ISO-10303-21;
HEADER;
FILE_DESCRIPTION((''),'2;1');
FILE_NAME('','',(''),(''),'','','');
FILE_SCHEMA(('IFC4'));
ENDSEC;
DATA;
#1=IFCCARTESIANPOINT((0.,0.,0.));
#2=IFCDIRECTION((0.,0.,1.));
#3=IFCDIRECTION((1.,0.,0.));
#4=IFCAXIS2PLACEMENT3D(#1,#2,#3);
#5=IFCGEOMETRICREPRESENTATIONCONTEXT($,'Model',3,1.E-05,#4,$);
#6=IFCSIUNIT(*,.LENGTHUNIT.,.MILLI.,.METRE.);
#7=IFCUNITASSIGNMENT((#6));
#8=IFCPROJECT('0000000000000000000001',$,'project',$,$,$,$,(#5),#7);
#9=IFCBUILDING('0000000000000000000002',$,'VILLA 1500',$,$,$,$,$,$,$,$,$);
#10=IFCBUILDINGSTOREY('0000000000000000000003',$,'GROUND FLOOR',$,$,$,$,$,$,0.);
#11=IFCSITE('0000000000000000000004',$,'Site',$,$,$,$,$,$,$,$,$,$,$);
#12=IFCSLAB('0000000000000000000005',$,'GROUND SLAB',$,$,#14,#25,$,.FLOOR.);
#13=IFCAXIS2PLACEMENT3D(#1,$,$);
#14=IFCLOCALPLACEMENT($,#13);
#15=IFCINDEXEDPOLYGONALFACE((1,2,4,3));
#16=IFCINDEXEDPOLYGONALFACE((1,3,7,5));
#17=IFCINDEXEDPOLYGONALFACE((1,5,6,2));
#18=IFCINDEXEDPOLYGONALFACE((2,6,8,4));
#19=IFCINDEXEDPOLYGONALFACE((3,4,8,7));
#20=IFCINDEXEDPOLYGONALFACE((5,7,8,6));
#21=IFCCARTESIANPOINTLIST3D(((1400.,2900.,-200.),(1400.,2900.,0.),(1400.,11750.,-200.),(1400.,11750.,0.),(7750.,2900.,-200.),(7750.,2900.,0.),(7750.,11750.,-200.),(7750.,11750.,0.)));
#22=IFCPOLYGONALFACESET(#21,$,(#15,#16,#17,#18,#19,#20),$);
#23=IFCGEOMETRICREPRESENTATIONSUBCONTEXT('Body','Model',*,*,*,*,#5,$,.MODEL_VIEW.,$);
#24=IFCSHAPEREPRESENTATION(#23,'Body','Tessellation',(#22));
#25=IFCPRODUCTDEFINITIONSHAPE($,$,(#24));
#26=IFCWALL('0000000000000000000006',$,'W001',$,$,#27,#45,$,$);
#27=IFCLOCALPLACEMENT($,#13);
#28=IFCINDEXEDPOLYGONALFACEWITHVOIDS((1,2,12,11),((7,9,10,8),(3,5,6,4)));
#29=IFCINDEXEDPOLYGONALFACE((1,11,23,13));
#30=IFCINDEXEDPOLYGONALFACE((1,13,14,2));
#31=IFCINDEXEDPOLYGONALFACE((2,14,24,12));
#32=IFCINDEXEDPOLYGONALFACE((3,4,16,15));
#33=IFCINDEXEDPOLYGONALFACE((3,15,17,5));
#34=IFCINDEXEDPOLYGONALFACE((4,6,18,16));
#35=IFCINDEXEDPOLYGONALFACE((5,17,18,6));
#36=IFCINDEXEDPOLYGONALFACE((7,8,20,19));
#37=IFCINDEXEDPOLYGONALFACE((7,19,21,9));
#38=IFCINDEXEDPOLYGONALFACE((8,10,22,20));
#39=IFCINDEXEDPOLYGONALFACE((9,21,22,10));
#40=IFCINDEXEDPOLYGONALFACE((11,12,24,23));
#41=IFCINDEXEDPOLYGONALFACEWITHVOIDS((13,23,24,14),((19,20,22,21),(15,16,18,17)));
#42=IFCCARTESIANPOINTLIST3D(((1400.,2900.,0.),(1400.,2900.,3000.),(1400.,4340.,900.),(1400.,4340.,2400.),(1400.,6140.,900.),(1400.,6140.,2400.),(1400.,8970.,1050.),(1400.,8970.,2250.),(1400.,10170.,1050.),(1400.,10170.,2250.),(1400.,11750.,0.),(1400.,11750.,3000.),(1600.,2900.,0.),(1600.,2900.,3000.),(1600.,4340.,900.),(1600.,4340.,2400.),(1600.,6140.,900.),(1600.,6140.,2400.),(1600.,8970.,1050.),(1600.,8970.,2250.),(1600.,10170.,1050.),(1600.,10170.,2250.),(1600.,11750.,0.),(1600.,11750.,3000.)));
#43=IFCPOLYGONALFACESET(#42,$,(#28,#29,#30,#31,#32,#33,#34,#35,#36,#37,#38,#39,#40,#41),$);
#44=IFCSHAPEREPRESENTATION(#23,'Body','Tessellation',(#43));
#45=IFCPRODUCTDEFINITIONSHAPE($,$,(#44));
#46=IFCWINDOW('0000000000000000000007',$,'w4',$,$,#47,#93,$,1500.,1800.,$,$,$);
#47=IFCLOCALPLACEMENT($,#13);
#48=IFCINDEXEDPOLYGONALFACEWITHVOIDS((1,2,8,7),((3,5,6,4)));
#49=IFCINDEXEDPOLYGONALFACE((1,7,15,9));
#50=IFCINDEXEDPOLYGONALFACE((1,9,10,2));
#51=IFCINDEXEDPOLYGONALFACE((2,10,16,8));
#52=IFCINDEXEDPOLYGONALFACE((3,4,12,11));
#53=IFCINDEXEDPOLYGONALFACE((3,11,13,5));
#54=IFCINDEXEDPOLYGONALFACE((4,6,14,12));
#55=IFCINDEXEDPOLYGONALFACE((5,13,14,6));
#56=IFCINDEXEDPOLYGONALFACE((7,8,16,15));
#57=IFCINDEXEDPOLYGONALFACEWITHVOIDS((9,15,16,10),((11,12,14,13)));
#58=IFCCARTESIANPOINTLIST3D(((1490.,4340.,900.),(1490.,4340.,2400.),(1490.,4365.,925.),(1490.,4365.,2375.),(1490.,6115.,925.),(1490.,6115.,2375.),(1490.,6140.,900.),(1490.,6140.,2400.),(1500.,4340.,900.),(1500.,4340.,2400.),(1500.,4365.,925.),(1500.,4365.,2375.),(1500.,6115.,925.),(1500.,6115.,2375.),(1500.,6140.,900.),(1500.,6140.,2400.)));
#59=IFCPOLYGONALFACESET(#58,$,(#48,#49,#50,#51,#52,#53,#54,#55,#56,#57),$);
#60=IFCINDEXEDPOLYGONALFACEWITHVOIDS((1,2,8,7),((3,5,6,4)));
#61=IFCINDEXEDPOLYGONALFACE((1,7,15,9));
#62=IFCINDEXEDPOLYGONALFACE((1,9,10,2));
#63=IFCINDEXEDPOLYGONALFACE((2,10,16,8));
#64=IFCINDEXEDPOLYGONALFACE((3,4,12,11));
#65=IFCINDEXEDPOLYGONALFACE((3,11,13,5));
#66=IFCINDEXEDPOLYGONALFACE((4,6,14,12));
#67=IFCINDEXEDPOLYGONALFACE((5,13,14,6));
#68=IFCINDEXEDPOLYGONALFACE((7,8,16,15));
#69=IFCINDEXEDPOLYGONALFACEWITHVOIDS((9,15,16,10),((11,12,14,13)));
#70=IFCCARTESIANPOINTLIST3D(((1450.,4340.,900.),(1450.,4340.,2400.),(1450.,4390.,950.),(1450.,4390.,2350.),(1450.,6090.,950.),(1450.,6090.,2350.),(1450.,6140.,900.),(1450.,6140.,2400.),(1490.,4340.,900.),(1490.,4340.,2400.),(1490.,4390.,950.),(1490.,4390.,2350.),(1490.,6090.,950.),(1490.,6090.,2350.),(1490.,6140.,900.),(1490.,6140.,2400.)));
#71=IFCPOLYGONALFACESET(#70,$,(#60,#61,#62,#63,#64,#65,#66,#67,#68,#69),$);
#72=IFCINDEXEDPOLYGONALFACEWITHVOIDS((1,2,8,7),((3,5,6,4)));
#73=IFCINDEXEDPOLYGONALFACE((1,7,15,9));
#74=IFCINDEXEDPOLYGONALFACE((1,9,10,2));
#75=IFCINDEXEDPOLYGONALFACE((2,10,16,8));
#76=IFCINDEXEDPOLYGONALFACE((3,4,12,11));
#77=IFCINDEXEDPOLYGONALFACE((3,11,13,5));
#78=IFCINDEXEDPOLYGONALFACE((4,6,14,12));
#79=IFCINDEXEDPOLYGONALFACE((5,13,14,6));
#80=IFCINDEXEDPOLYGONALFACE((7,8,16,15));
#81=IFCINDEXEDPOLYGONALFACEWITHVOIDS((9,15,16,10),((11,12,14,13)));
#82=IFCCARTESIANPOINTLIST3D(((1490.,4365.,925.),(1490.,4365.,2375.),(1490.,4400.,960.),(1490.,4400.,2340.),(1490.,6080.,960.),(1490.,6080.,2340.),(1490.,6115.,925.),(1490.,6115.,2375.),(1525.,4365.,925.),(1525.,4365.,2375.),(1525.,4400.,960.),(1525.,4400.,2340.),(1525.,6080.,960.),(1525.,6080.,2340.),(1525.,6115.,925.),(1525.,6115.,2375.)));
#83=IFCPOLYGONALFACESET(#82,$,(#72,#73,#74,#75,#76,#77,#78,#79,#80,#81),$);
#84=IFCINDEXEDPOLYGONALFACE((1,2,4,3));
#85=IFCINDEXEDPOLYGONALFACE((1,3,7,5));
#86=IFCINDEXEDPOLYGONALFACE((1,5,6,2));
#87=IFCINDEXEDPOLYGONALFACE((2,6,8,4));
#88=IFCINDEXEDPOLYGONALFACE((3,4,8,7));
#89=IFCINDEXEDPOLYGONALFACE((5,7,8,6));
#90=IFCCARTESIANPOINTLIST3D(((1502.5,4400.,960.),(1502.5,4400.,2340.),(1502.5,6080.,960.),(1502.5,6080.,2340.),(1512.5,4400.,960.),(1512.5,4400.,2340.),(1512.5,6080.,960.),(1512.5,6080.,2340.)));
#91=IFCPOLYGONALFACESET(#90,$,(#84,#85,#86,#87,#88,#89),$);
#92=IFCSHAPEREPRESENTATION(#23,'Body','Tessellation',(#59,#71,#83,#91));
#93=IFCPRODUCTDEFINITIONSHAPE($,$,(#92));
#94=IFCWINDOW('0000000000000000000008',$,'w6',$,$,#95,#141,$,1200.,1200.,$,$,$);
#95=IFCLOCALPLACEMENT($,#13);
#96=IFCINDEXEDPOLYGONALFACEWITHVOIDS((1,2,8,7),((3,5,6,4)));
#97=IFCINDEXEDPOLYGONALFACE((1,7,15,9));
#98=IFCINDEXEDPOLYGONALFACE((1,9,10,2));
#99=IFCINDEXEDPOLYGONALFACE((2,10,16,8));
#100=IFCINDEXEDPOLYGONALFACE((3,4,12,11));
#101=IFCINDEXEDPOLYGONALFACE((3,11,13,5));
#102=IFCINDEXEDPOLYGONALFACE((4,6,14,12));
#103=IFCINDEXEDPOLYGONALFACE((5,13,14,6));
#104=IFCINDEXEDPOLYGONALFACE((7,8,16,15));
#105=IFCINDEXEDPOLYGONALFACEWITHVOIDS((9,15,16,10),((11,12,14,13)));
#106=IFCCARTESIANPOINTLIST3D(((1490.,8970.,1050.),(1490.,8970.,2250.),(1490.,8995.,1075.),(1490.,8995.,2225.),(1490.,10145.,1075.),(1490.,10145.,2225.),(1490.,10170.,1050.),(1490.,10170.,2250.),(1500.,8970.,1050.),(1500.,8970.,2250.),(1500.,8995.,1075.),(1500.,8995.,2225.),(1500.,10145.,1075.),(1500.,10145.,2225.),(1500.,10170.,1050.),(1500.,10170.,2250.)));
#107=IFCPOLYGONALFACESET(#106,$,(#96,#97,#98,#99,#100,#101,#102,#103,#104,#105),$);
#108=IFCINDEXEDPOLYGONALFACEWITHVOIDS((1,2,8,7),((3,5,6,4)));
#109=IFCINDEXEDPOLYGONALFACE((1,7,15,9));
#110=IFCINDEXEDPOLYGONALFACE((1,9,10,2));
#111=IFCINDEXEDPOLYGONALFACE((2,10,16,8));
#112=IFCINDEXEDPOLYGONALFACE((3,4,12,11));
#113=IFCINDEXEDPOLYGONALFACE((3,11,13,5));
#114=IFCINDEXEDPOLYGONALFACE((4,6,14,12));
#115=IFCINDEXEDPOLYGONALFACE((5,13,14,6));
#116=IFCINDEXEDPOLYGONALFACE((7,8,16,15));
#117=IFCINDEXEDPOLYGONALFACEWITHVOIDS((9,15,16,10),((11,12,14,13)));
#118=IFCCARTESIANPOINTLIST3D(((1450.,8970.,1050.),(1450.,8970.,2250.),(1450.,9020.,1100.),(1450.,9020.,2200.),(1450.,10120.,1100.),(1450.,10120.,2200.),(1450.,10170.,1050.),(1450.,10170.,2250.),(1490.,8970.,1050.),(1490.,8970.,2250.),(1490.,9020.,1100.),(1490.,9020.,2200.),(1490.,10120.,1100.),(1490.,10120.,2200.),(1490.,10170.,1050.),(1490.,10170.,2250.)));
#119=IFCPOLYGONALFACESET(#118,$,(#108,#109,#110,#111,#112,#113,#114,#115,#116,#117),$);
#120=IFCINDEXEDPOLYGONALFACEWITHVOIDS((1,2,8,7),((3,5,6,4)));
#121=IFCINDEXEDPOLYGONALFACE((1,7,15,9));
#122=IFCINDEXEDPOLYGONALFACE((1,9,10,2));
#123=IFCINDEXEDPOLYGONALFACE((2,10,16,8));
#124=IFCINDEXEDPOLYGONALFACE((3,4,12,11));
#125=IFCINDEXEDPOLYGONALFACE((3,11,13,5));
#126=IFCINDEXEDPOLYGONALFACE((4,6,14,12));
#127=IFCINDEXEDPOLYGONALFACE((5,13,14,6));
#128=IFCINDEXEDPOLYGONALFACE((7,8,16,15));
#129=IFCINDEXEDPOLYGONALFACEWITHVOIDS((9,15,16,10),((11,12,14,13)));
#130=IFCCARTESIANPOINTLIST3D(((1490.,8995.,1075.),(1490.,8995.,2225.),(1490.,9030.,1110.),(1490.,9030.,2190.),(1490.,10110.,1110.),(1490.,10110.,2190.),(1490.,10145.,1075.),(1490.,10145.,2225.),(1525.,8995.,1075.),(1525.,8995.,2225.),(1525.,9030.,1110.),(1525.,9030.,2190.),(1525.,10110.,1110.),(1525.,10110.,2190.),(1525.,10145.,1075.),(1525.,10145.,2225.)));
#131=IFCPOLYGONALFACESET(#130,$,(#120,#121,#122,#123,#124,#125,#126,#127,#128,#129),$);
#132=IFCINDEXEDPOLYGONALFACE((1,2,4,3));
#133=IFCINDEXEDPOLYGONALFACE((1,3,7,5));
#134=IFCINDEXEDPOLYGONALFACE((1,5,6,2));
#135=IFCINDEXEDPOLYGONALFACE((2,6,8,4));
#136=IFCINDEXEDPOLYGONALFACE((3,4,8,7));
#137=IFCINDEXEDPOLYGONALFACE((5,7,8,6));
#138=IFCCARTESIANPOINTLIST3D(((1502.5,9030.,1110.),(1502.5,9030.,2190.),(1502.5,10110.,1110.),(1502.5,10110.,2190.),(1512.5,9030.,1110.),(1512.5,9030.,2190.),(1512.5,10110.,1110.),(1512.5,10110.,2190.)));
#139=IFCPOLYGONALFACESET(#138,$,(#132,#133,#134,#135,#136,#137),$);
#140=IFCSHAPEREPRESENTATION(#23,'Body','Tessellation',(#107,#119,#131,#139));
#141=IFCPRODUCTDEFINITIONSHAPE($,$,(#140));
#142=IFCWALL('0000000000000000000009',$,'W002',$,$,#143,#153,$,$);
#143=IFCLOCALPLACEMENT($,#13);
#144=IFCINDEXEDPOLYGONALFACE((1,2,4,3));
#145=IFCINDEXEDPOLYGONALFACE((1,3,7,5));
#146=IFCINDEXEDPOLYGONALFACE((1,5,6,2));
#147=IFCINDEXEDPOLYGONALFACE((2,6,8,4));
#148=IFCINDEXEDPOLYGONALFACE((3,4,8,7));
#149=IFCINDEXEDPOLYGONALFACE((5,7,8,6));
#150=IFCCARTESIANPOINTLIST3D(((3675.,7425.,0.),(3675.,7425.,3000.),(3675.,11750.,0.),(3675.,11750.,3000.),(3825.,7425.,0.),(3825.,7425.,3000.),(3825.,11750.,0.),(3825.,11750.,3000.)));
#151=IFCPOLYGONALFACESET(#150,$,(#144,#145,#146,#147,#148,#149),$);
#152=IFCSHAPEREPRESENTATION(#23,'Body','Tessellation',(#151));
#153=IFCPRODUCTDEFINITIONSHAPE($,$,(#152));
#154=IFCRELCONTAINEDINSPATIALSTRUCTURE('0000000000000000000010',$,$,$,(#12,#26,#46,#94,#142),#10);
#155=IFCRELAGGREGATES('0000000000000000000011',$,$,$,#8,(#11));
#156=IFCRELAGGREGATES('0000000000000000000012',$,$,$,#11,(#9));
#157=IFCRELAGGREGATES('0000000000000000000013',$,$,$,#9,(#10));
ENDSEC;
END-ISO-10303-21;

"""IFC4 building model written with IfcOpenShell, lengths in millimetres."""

from ifc_helpers import new_model, si_unit, frame, origin_with_axes, place, context, subcontext, project, spatial, line, indexed_curve, outline, extrude, element, fill, save


model = new_model("IFC4")

# Units and contexts
model_context = context("Model", 3, precision=1e-05, world=origin_with_axes())
body_context = subcontext(model_context, "Body", "Model", "MODEL_VIEW")
ifc_project = project(units=[si_unit("LENGTHUNIT", "METRE", prefix="MILLI")], contexts=[model_context])

# Site, building, storey
site = spatial("IfcSite", under=ifc_project, Name="Site")
building = spatial("IfcBuilding", under=site, Name="VILLA 1500")
storey = spatial("IfcBuildingStorey", under=building, Name="GROUND FLOOR", Elevation=0.0)

# Slab
slab_placement = place(None, frame((0.0, 0.0, -200.0), z_axis=(0.0, 0.0, 1.0), x_axis=(1.0, 0.0, 0.0)))
element("IfcSlab", 1, at=slab_placement, inside=storey, Name="GROUND SLAB", PredefinedType="FLOOR", context=body_context, shape_type="SweptSolid", body=[
    extrude(outline(indexed_curve([(1400.0, 2900.0), (7750.0, 2900.0), (7750.0, 11750.0), (1400.0, 11750.0)])), None, (0.0, 0.0, 1.0), 200.0),
])

# Wall, openings, windows
wall_1_placement = place(None, frame((1500.0, 11750.0, 0.0), z_axis=(0.0, 0.0, 1.0), x_axis=(0.0, -1.0, 0.0)))
wall_1 = element("IfcWall", 2, at=wall_1_placement, inside=storey, Name="W001", context=body_context, shape_type="SweptSolid", body=[
    extrude(outline(indexed_curve([(0.0, 0.0), (0.0, 200.0), (8850.0, 200.0), (8850.0, 0.0), (0.0, 0.0)], self_intersect=False)), frame((0.0, -100.0, 0.0), z_axis=(0.0, 0.0, 1.0), x_axis=(1.0, 0.0, 0.0)), (0.0, 0.0, 1.0), 3000.0),
])
opening_1_placement = place(wall_1_placement, frame((5610.0, 0.0, 900.0), z_axis=(0.0, 0.0, 1.0), x_axis=(1.0, 0.0, 0.0)))
opening_1 = element("IfcOpeningElement", 3, at=opening_1_placement, cuts=wall_1, context=body_context, shape_type="SweptSolid", body=[
    extrude(outline(indexed_curve([(0.0, 0.0), (0.0, 300.0), (1800.0, 300.0), (1800.0, 0.0), (0.0, 0.0)], self_intersect=False)), frame((0.0, -150.0, 0.0), z_axis=(0.0, 0.0, 1.0), x_axis=(1.0, 0.0, 0.0)), (0.0, 0.0, 1.0), 1500.0),
])
opening_2_placement = place(wall_1_placement, frame((1580.0, 0.0, 1050.0), z_axis=(0.0, 0.0, 1.0), x_axis=(1.0, 0.0, 0.0)))
opening_2 = element("IfcOpeningElement", 4, at=opening_2_placement, cuts=wall_1, context=body_context, shape_type="SweptSolid", body=[
    extrude(outline(indexed_curve([(0.0, 0.0), (0.0, 300.0), (1200.0, 300.0), (1200.0, 0.0), (0.0, 0.0)], self_intersect=False)), frame((0.0, -150.0, 0.0), z_axis=(0.0, 0.0, 1.0), x_axis=(1.0, 0.0, 0.0)), (0.0, 0.0, 1.0), 1200.0),
])
window_1_placement = place(None, frame((1400.0, 6140.0, 900.0), z_axis=(0.0, 0.0, 1.0), x_axis=(0.0, -1.0, 0.0)))
window_1 = element("IfcWindow", 5, at=window_1_placement, inside=storey, Name="w4", OverallHeight=1500.0, OverallWidth=1800.0, context=body_context, shape_type="SweptSolid", body=[
    extrude(outline(indexed_curve([(0.0, 0.0), (1800.0, 0.0), (1800.0, 1500.0), (0.0, 1500.0)], segments=[line(1, 2, 3, 4, 1)]), holes=[indexed_curve([(25.0, 25.0), (1775.0, 25.0), (1775.0, 1475.0), (25.0, 1475.0)], segments=[line(1, 2, 3, 4, 1)])]), frame((0.0, 90.0, 0.0), z_axis=(0.0, -1.0, 0.0), x_axis=(1.0, 0.0, 0.0)), (0.0, 0.0, -1.0), 10.0),
    extrude(outline(indexed_curve([(0.0, 0.0), (1800.0, 0.0), (1800.0, 1500.0), (0.0, 1500.0)], segments=[line(1, 2, 3, 4, 1)]), holes=[indexed_curve([(50.0, 50.0), (1750.0, 50.0), (1750.0, 1450.0), (50.0, 1450.0)], segments=[line(1, 2, 3, 4, 1)])]), frame((0.0, 50.0, 0.0), z_axis=(0.0, -1.0, 0.0), x_axis=(1.0, 0.0, 0.0)), (0.0, 0.0, -1.0), 40.0),
    extrude(outline(indexed_curve([(0.0, 0.0), (1750.0, 0.0), (1750.0, 1450.0), (0.0, 1450.0)], segments=[line(1, 2, 3, 4, 1)]), holes=[indexed_curve([(35.0, 35.0), (1715.0, 35.0), (1715.0, 1415.0), (35.0, 1415.0)], segments=[line(1, 2, 3, 4, 1)])]), frame((25.0, 90.0, 25.0), z_axis=(0.0, -1.0, 0.0), x_axis=(1.0, 0.0, 0.0)), (0.0, 0.0, -1.0), 35.0),
    extrude(outline(indexed_curve([(35.0, 35.0), (1715.0, 35.0), (1715.0, 1415.0), (35.0, 1415.0)], segments=[line(1, 2, 3, 4, 1)])), frame((25.0, 102.5, 25.0), z_axis=(0.0, -1.0, 0.0), x_axis=(1.0, 0.0, 0.0)), (0.0, 0.0, -1.0), 10.0),
])
fill(opening_1, window_1)
window_2_placement = place(None, frame((1400.0, 10170.0, 1050.0), z_axis=(0.0, 0.0, 1.0), x_axis=(0.0, -1.0, 0.0)))
window_2 = element("IfcWindow", 6, at=window_2_placement, inside=storey, Name="w6", OverallHeight=1200.0, OverallWidth=1200.0, context=body_context, shape_type="SweptSolid", body=[
    extrude(outline(indexed_curve([(0.0, 0.0), (1200.0, 0.0), (1200.0, 1200.0), (0.0, 1200.0)], segments=[line(1, 2, 3, 4, 1)]), holes=[indexed_curve([(25.0, 25.0), (1175.0, 25.0), (1175.0, 1175.0), (25.0, 1175.0)], segments=[line(1, 2, 3, 4, 1)])]), frame((0.0, 90.0, 0.0), z_axis=(0.0, -1.0, 0.0), x_axis=(1.0, 0.0, 0.0)), (0.0, 0.0, -1.0), 10.0),
    extrude(outline(indexed_curve([(0.0, 0.0), (1200.0, 0.0), (1200.0, 1200.0), (0.0, 1200.0)], segments=[line(1, 2, 3, 4, 1)]), holes=[indexed_curve([(50.0, 50.0), (1150.0, 50.0), (1150.0, 1150.0), (50.0, 1150.0)], segments=[line(1, 2, 3, 4, 1)])]), frame((0.0, 50.0, 0.0), z_axis=(0.0, -1.0, 0.0), x_axis=(1.0, 0.0, 0.0)), (0.0, 0.0, -1.0), 40.0),
    extrude(outline(indexed_curve([(0.0, 0.0), (1150.0, 0.0), (1150.0, 1150.0), (0.0, 1150.0)], segments=[line(1, 2, 3, 4, 1)]), holes=[indexed_curve([(35.0, 35.0), (1115.0, 35.0), (1115.0, 1115.0), (35.0, 1115.0)], segments=[line(1, 2, 3, 4, 1)])]), frame((25.0, 90.0, 25.0), z_axis=(0.0, -1.0, 0.0), x_axis=(1.0, 0.0, 0.0)), (0.0, 0.0, -1.0), 35.0),
    extrude(outline(indexed_curve([(35.0, 35.0), (1115.0, 35.0), (1115.0, 1115.0), (35.0, 1115.0)], segments=[line(1, 2, 3, 4, 1)])), frame((25.0, 102.5, 25.0), z_axis=(0.0, -1.0, 0.0), x_axis=(1.0, 0.0, 0.0)), (0.0, 0.0, -1.0), 10.0),
])
fill(opening_2, window_2)

# Wall
wall_2_placement = place(None, frame((3750.0, 11750.0, 0.0), z_axis=(0.0, 0.0, 1.0), x_axis=(0.0, -1.0, 0.0)))
element("IfcWall", 7, at=wall_2_placement, inside=storey, Name="W002", context=body_context, shape_type="SweptSolid", body=[
    extrude(outline(indexed_curve([(0.0, 0.0), (0.0, 150.0), (4325.0, 150.0), (4325.0, 0.0), (0.0, 0.0)], self_intersect=False)), frame((0.0, -75.0, 0.0), z_axis=(0.0, 0.0, 1.0), x_axis=(1.0, 0.0, 0.0)), (0.0, 0.0, 1.0), 3000.0),
])

save(model, "model.ifc")
